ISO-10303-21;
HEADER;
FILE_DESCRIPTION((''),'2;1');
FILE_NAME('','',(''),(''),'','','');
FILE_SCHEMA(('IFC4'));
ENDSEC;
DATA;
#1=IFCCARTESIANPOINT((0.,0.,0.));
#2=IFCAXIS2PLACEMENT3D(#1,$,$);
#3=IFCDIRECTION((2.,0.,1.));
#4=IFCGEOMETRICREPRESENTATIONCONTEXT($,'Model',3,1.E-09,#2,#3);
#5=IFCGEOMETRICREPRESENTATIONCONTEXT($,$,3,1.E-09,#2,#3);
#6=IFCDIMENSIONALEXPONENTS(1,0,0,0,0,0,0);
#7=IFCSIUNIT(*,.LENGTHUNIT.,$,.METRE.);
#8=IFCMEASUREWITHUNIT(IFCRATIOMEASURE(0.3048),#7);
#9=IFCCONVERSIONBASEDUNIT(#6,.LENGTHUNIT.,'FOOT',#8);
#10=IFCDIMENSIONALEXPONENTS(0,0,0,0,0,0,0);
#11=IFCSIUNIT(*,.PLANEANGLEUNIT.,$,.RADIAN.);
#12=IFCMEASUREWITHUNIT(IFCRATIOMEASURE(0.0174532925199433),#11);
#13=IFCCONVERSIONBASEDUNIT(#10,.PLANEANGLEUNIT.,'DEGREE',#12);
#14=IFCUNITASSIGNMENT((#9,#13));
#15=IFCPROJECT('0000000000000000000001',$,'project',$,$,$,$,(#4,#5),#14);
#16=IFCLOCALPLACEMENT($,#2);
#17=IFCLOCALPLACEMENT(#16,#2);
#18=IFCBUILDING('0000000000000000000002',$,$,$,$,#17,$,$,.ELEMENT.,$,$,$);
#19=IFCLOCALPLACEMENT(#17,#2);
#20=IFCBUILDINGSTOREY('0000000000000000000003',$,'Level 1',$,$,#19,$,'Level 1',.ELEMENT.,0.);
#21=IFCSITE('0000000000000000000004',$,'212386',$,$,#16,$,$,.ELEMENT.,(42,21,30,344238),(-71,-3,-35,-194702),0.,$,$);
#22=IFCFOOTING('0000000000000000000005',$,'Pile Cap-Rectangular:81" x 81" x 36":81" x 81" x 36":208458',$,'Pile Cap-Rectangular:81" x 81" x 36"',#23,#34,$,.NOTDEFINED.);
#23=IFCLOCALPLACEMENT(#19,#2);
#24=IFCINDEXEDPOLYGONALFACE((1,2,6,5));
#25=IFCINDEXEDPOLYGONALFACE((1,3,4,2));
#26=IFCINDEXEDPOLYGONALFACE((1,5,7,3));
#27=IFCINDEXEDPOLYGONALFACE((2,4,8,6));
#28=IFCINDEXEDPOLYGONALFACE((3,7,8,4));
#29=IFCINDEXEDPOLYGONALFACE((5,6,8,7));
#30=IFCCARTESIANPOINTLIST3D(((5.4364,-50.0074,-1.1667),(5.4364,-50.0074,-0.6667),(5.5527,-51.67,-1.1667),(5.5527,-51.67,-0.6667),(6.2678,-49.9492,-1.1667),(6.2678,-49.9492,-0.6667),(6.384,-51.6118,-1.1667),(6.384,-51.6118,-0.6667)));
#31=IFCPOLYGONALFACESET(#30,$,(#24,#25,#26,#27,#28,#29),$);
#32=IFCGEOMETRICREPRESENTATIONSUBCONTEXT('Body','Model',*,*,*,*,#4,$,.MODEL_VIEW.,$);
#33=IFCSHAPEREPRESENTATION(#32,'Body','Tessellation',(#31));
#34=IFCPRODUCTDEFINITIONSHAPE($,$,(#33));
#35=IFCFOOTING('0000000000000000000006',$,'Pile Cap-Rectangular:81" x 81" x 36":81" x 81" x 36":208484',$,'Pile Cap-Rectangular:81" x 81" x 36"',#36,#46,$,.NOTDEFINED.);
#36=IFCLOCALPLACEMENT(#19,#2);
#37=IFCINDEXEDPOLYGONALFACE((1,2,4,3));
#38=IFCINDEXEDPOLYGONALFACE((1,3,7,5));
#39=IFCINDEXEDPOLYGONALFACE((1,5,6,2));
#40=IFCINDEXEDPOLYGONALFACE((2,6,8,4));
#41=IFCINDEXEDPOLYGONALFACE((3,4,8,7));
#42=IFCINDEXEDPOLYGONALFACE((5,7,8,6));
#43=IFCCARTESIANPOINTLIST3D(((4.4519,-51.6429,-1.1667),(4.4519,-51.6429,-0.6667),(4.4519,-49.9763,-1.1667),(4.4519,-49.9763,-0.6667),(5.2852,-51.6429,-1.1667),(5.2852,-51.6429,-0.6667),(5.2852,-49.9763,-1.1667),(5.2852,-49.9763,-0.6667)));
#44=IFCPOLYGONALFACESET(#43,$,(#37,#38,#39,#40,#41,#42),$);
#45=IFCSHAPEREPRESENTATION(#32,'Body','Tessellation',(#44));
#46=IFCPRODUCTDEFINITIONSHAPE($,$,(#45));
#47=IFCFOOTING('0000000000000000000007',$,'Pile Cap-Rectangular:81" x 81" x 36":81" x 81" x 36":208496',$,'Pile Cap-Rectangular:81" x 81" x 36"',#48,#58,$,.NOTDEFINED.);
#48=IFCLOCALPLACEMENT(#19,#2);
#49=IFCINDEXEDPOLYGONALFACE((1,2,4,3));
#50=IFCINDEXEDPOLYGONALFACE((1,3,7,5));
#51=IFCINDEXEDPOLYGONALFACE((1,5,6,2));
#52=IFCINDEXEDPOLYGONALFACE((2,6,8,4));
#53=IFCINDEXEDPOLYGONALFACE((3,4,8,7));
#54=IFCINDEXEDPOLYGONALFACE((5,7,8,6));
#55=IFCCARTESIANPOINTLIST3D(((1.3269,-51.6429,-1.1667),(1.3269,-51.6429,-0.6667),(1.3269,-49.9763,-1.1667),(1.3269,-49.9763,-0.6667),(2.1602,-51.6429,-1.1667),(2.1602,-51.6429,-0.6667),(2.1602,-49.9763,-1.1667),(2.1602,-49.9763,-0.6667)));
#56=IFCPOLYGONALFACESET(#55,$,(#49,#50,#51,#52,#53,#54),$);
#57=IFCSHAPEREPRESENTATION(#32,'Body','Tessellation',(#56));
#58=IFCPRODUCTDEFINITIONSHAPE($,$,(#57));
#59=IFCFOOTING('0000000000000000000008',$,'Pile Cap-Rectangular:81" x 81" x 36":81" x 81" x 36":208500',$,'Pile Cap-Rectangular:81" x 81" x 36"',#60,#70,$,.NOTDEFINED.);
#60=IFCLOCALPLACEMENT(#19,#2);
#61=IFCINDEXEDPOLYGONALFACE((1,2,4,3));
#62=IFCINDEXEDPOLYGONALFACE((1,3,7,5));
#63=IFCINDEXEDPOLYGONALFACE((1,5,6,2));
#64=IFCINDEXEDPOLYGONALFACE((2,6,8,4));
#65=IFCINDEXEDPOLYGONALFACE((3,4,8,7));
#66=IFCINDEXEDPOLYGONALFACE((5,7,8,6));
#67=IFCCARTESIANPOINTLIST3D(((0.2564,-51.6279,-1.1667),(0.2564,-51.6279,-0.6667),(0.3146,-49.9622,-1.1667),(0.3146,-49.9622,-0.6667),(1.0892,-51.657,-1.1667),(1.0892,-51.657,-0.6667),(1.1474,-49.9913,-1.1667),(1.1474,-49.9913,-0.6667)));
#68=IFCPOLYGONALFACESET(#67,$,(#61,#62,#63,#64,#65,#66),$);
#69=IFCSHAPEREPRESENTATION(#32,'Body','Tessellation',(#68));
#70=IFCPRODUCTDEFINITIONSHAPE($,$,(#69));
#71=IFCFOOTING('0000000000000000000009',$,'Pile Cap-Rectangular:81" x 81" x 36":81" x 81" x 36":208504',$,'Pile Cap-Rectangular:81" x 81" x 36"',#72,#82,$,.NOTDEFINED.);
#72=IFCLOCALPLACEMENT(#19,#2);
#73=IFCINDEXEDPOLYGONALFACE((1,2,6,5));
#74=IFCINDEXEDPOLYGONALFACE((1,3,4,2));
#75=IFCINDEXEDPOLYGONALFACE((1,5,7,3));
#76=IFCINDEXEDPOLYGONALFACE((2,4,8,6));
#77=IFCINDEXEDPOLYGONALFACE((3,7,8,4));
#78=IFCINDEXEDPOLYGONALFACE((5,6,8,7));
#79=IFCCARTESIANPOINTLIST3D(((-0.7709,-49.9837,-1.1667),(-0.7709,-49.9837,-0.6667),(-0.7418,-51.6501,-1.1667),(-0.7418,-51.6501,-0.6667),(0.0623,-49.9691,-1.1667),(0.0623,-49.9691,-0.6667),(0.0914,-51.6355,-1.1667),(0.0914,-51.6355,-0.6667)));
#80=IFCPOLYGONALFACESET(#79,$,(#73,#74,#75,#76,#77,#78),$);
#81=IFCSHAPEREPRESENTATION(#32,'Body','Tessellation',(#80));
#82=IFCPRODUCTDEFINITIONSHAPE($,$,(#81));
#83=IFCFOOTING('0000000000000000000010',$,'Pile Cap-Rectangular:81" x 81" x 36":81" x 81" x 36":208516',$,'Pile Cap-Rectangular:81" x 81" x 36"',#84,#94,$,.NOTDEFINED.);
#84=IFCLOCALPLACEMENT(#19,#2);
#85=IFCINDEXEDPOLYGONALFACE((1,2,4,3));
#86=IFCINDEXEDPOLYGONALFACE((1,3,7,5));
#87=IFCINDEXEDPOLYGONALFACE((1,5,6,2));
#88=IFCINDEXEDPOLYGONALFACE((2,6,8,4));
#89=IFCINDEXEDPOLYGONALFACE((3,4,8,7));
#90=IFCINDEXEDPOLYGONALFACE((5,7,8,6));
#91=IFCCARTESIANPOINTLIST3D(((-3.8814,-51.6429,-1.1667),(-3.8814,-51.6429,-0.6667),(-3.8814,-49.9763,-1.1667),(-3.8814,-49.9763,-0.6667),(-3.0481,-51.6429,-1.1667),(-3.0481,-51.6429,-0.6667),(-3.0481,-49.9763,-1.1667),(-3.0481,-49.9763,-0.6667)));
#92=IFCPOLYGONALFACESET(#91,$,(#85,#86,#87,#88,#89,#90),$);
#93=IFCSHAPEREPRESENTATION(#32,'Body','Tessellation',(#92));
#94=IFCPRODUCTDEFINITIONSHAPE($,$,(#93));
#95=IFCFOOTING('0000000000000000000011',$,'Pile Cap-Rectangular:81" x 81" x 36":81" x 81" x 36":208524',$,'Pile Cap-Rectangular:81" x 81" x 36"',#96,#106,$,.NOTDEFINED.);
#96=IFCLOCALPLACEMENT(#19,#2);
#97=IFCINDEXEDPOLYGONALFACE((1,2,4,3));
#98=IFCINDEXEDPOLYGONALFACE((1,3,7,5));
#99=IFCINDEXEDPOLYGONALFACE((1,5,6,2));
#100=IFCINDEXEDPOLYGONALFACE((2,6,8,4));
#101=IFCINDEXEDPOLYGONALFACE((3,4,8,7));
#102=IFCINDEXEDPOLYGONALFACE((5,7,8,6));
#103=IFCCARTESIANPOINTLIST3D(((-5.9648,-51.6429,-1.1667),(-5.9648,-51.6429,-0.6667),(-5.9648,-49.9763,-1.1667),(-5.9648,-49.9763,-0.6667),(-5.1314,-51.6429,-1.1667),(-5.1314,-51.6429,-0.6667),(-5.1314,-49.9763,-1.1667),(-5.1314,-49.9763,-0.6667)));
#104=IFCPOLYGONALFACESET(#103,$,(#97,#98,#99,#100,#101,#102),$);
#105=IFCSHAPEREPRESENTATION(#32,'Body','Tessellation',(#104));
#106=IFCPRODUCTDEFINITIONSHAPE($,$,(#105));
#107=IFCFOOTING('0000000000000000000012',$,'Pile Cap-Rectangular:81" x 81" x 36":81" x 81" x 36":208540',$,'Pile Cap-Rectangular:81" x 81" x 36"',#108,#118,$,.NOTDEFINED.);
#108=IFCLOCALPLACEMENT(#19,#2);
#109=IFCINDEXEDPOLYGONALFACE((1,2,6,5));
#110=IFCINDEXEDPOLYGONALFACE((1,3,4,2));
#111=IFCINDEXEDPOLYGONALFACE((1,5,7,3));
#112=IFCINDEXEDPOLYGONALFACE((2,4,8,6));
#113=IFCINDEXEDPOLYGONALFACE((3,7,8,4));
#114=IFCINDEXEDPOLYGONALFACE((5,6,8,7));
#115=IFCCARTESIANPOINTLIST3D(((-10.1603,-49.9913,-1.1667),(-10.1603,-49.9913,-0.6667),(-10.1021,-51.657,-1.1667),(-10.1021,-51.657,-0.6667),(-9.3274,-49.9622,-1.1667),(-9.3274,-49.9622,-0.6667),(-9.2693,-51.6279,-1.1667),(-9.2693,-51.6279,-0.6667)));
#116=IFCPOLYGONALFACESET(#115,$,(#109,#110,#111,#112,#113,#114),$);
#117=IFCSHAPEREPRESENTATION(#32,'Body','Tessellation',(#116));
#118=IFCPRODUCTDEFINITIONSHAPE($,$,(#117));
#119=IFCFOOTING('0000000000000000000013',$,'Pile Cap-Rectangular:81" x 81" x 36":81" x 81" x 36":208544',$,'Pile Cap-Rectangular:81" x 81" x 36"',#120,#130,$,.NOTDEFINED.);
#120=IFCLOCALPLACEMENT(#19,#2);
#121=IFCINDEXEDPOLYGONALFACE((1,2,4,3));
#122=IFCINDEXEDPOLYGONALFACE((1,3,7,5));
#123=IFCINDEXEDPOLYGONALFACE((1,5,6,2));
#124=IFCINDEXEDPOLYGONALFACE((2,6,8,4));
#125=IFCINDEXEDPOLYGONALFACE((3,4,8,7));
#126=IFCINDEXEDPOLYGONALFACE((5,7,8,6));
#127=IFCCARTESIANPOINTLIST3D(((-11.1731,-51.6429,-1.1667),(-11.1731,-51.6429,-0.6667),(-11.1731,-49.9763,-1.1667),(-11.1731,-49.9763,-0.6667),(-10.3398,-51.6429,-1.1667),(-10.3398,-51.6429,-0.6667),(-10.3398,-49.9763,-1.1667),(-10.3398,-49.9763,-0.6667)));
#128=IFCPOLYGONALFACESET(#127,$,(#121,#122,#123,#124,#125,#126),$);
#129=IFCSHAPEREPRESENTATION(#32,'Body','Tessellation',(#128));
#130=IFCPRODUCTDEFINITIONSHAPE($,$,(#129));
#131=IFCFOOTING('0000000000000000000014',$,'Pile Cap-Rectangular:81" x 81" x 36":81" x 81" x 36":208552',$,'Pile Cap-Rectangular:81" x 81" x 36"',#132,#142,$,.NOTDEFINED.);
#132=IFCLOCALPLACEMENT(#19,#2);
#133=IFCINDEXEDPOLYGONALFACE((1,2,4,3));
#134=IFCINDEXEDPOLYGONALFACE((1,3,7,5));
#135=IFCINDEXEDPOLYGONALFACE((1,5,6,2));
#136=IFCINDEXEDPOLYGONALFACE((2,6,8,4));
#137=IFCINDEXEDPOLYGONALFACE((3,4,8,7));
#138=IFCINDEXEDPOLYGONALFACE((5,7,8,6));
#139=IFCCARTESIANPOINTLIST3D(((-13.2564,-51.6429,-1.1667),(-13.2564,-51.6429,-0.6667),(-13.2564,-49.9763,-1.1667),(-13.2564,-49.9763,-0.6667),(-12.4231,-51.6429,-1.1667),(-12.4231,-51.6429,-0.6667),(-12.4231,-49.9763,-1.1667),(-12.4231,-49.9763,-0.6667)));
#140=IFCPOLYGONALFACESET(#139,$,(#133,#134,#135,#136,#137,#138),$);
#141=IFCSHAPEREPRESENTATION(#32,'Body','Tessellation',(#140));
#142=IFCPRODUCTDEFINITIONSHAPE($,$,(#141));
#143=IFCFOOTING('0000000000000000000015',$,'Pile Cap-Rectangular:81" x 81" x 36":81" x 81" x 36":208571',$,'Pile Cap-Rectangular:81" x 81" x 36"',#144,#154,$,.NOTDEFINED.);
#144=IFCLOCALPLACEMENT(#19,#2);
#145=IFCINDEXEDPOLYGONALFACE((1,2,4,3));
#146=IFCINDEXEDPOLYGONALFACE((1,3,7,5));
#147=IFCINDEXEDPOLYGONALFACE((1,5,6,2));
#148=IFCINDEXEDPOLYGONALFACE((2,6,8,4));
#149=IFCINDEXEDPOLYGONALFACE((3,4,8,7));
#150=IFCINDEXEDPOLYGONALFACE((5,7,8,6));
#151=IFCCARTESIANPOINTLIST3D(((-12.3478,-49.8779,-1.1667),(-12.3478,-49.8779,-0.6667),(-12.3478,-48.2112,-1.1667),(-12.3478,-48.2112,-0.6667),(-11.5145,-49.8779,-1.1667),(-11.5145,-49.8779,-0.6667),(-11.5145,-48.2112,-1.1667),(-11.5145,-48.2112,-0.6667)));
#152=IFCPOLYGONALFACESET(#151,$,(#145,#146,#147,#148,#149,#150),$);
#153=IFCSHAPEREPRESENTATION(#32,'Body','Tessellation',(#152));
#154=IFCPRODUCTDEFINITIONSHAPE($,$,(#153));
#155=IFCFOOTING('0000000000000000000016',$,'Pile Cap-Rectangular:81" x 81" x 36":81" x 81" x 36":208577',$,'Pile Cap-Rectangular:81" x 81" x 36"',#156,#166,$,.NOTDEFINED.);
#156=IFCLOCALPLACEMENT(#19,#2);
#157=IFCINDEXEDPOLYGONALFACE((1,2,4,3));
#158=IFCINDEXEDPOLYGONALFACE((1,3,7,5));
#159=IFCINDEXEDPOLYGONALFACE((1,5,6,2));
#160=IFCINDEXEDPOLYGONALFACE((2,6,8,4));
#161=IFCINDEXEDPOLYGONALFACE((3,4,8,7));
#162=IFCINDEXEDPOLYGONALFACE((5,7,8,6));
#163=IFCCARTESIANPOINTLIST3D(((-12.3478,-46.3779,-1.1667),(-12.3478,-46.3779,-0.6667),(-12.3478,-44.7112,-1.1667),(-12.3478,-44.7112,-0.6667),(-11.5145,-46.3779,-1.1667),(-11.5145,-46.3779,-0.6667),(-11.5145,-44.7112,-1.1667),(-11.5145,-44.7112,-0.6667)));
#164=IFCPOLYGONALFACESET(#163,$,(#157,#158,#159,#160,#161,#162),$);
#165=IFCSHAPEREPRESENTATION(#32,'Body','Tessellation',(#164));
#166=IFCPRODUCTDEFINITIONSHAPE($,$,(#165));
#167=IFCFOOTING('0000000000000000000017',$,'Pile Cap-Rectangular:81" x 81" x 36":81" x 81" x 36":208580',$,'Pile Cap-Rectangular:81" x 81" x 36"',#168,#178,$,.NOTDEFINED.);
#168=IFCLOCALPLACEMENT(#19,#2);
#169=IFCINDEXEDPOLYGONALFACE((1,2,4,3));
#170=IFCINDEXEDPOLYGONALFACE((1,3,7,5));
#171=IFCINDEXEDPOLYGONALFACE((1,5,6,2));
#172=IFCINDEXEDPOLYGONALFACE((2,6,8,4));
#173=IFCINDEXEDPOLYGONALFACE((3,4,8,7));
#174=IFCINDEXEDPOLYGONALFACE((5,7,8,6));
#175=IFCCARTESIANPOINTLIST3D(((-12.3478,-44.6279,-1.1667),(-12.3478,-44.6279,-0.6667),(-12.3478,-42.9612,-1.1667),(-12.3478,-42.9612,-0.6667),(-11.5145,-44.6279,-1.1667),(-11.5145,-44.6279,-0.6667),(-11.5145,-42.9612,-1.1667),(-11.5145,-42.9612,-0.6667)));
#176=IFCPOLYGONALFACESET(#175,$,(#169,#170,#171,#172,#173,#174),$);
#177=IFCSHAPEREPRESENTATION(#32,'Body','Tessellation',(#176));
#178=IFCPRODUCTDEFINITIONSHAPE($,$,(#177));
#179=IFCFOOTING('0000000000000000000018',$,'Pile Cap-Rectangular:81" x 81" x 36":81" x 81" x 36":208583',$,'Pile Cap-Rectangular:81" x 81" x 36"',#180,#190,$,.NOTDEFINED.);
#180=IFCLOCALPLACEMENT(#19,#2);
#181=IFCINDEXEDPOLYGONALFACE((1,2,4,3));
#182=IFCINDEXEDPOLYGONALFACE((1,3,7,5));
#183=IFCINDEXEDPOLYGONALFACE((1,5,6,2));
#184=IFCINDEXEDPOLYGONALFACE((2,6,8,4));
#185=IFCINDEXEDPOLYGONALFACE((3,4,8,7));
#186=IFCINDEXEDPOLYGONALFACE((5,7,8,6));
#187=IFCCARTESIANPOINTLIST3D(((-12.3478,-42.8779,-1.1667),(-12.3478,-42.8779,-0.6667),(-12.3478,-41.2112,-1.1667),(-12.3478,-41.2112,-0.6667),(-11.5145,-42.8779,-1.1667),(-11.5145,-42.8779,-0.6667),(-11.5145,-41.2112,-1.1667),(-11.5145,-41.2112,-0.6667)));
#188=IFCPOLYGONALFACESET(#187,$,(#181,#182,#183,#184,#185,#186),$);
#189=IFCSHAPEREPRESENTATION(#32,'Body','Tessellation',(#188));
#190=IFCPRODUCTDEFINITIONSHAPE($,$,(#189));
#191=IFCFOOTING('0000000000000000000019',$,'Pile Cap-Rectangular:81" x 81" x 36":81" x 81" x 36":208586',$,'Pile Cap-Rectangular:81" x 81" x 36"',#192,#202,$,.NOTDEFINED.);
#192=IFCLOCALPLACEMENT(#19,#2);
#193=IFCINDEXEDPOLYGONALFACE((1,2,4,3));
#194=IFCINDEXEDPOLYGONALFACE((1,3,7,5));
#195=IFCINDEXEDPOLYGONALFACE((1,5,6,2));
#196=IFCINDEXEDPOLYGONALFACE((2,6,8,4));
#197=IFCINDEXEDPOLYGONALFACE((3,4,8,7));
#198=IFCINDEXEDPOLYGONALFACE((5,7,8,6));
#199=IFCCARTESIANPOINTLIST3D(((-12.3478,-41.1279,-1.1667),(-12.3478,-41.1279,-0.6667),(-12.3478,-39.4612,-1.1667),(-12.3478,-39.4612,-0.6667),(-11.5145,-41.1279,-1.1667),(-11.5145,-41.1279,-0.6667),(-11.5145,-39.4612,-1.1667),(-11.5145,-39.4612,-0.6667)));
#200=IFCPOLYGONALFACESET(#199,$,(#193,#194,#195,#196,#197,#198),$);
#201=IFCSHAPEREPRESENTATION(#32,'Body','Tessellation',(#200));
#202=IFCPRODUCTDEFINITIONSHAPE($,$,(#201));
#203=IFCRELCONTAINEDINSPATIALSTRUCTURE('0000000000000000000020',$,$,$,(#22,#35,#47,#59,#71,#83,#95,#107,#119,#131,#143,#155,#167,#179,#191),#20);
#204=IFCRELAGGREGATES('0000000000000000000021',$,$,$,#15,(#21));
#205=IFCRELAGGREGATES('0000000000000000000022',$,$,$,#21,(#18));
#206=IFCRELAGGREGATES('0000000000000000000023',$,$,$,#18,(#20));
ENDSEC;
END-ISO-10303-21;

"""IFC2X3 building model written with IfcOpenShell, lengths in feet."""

from ifc_helpers import new_model, entity, si_unit, converted_unit, direction, frame, frame_2d, origin, origin_2d_with_axis, place, context, subcontext, project, spatial, rectangle, extrude, element, save


model = new_model("IFC2X3")

# Units and contexts
model_context = context("Model", 3, precision=1e-09, world=origin(), true_north=direction((2.0, 0.0, 1.0)))
context_of_model = context(None, 3, precision=1e-09, world=origin(), true_north=direction((2.0, 0.0, 1.0)))
body_context = subcontext(model_context, "Body", "Model", "MODEL_VIEW")
ifc_project = project(units=[converted_unit("LENGTHUNIT", "FOOT", entity("IfcRatioMeasure", 0.3048), si_unit("LENGTHUNIT", "METRE"), dimensions=[1, 0, 0, 0, 0, 0, 0]), converted_unit("PLANEANGLEUNIT", "DEGREE", entity("IfcRatioMeasure", 0.0174532925199433), si_unit("PLANEANGLEUNIT", "RADIAN"), dimensions=[0, 0, 0, 0, 0, 0, 0])], contexts=[model_context, context_of_model])

# Site, building, storey
site_placement = place(None, origin())
site = spatial("IfcSite", under=ifc_project, at=site_placement, Name="212386", CompositionType="ELEMENT", RefLatitude=(42, 21, 30, 344238), RefLongitude=(-71, -3, -35, -194702), RefElevation=0.0)
building_placement = place(site_placement, origin())
building = spatial("IfcBuilding", under=site, at=building_placement, CompositionType="ELEMENT")
storey_placement = place(building_placement, origin())
storey = spatial("IfcBuildingStorey", under=building, at=storey_placement, Name="Level 1", LongName="Level 1", CompositionType="ELEMENT", Elevation=0.0)

# Footings
footing_1_placement = place(storey_placement, origin())
element("IfcFooting", 1, at=footing_1_placement, inside=storey, Name="Pile Cap-Rectangular:81\" x 81\" x 36\":81\" x 81\" x 36\":208458", ObjectType="Pile Cap-Rectangular:81\" x 81\" x 36\"", PredefinedType="NOTDEFINED", context=body_context, shape_type="SweptSolid", body=[
    extrude(rectangle(XDim=0.8333, YDim=1.6667, at=frame_2d((0.0, 0.0), x_axis=(1.0, 0.0))), frame((5.9102, -50.8096, -1.1667), z_axis=(0.0, 0.0, 1.0), x_axis=(-0.997564, -0.069756, 0.0)), (0.0, 0.0, 1.0), 0.5),
])
footing_2_placement = place(storey_placement, origin())
element("IfcFooting", 2, at=footing_2_placement, inside=storey, Name="Pile Cap-Rectangular:81\" x 81\" x 36\":81\" x 81\" x 36\":208484", ObjectType="Pile Cap-Rectangular:81\" x 81\" x 36\"", PredefinedType="NOTDEFINED", context=body_context, shape_type="SweptSolid", body=[
    extrude(rectangle(XDim=0.8333, YDim=1.6667, at=frame_2d((0.0, 0.0), x_axis=(1.0, 0.0))), frame((4.8686, -50.8096, -1.1667), z_axis=(0.0, 0.0, 1.0), x_axis=(-1.0, 0.0, 0.0)), (0.0, 0.0, 1.0), 0.5),
])
footing_3_placement = place(storey_placement, origin())
element("IfcFooting", 3, at=footing_3_placement, inside=storey, Name="Pile Cap-Rectangular:81\" x 81\" x 36\":81\" x 81\" x 36\":208496", ObjectType="Pile Cap-Rectangular:81\" x 81\" x 36\"", PredefinedType="NOTDEFINED", context=body_context, shape_type="SweptSolid", body=[
    extrude(rectangle(XDim=0.8333, YDim=1.6667, at=frame_2d((0.0, 0.0), x_axis=(1.0, 0.0))), frame((1.7436, -50.8096, -1.1667), z_axis=(0.0, 0.0, 1.0), x_axis=(-1.0, 0.0, 0.0)), (0.0, 0.0, 1.0), 0.5),
])
footing_4_placement = place(storey_placement, origin())
element("IfcFooting", 4, at=footing_4_placement, inside=storey, Name="Pile Cap-Rectangular:81\" x 81\" x 36\":81\" x 81\" x 36\":208500", ObjectType="Pile Cap-Rectangular:81\" x 81\" x 36\"", PredefinedType="NOTDEFINED", context=body_context, shape_type="SweptSolid", body=[
    extrude(rectangle(XDim=0.8333, YDim=1.6667, at=frame_2d((0.0, 0.0), x_axis=(1.0, 0.0))), frame((0.7019, -50.8096, -1.1667), z_axis=(0.0, 0.0, 1.0), x_axis=(-0.999391, 0.034899, 0.0)), (0.0, 0.0, 1.0), 0.5),
])
footing_5_placement = place(storey_placement, origin())
element("IfcFooting", 5, at=footing_5_placement, inside=storey, Name="Pile Cap-Rectangular:81\" x 81\" x 36\":81\" x 81\" x 36\":208504", ObjectType="Pile Cap-Rectangular:81\" x 81\" x 36\"", PredefinedType="NOTDEFINED", context=body_context, shape_type="SweptSolid", body=[
    extrude(rectangle(XDim=0.8333, YDim=1.6667, at=frame_2d((0.0, 0.0), x_axis=(1.0, 0.0))), frame((-0.3398, -50.8096, -1.1667), z_axis=(0.0, 0.0, 1.0), x_axis=(-0.999848, -0.017452, 0.0)), (0.0, 0.0, 1.0), 0.5),
])
footing_6_placement = place(storey_placement, origin())
element("IfcFooting", 6, at=footing_6_placement, inside=storey, Name="Pile Cap-Rectangular:81\" x 81\" x 36\":81\" x 81\" x 36\":208516", ObjectType="Pile Cap-Rectangular:81\" x 81\" x 36\"", PredefinedType="NOTDEFINED", context=body_context, shape_type="SweptSolid", body=[
    extrude(rectangle(XDim=0.8333, YDim=1.6667, at=frame_2d((0.0, 0.0), x_axis=(1.0, 0.0))), frame((-3.4648, -50.8096, -1.1667), z_axis=(0.0, 0.0, 1.0), x_axis=(-1.0, 0.0, 0.0)), (0.0, 0.0, 1.0), 0.5),
])
footing_7_placement = place(storey_placement, origin())
element("IfcFooting", 7, at=footing_7_placement, inside=storey, Name="Pile Cap-Rectangular:81\" x 81\" x 36\":81\" x 81\" x 36\":208524", ObjectType="Pile Cap-Rectangular:81\" x 81\" x 36\"", PredefinedType="NOTDEFINED", context=body_context, shape_type="SweptSolid", body=[
    extrude(rectangle(XDim=0.8333, YDim=1.6667, at=frame_2d((0.0, 0.0), x_axis=(1.0, 0.0))), frame((-5.5481, -50.8096, -1.1667), z_axis=(0.0, 0.0, 1.0), x_axis=(-1.0, 0.0, 0.0)), (0.0, 0.0, 1.0), 0.5),
])
footing_8_placement = place(storey_placement, origin())
element("IfcFooting", 8, at=footing_8_placement, inside=storey, Name="Pile Cap-Rectangular:81\" x 81\" x 36\":81\" x 81\" x 36\":208540", ObjectType="Pile Cap-Rectangular:81\" x 81\" x 36\"", PredefinedType="NOTDEFINED", context=body_context, shape_type="SweptSolid", body=[
    extrude(rectangle(XDim=0.8333, YDim=1.6667, at=origin_2d_with_axis()), frame((-9.7148, -50.8096, -1.1667), z_axis=(0.0, 0.0, 1.0), x_axis=(-0.999391, -0.034899, 0.0)), (0.0, 0.0, 1.0), 0.5),
])
footing_9_placement = place(storey_placement, origin())
element("IfcFooting", 9, at=footing_9_placement, inside=storey, Name="Pile Cap-Rectangular:81\" x 81\" x 36\":81\" x 81\" x 36\":208544", ObjectType="Pile Cap-Rectangular:81\" x 81\" x 36\"", PredefinedType="NOTDEFINED", context=body_context, shape_type="SweptSolid", body=[
    extrude(rectangle(XDim=0.8333, YDim=1.6667, at=frame_2d((0.0, 0.0), x_axis=(1.0, 0.0))), frame((-10.7564, -50.8096, -1.1667), z_axis=(0.0, 0.0, 1.0), x_axis=(-1.0, 0.0, 0.0)), (0.0, 0.0, 1.0), 0.5),
])
footing_10_placement = place(storey_placement, origin())
element("IfcFooting", 10, at=footing_10_placement, inside=storey, Name="Pile Cap-Rectangular:81\" x 81\" x 36\":81\" x 81\" x 36\":208552", ObjectType="Pile Cap-Rectangular:81\" x 81\" x 36\"", PredefinedType="NOTDEFINED", context=body_context, shape_type="SweptSolid", body=[
    extrude(rectangle(XDim=0.8333, YDim=1.6667, at=frame_2d((0.0, 0.0), x_axis=(1.0, 0.0))), frame((-12.8398, -50.8096, -1.1667), z_axis=(0.0, 0.0, 1.0), x_axis=(-1.0, 0.0, 0.0)), (0.0, 0.0, 1.0), 0.5),
])
footing_11_placement = place(storey_placement, origin())
element("IfcFooting", 11, at=footing_11_placement, inside=storey, Name="Pile Cap-Rectangular:81\" x 81\" x 36\":81\" x 81\" x 36\":208571", ObjectType="Pile Cap-Rectangular:81\" x 81\" x 36\"", PredefinedType="NOTDEFINED", context=body_context, shape_type="SweptSolid", body=[
    extrude(rectangle(XDim=0.8333, YDim=1.6667, at=frame_2d((0.0, 0.0), x_axis=(1.0, 0.0))), frame((-11.9311, -49.0446, -1.1667), z_axis=(0.0, 0.0, 1.0), x_axis=(-1.0, 0.0, 0.0)), (0.0, 0.0, 1.0), 0.5),
])
footing_12_placement = place(storey_placement, origin())
element("IfcFooting", 12, at=footing_12_placement, inside=storey, Name="Pile Cap-Rectangular:81\" x 81\" x 36\":81\" x 81\" x 36\":208577", ObjectType="Pile Cap-Rectangular:81\" x 81\" x 36\"", PredefinedType="NOTDEFINED", context=body_context, shape_type="SweptSolid", body=[
    extrude(rectangle(XDim=0.8333, YDim=1.6667, at=frame_2d((0.0, 0.0), x_axis=(1.0, 0.0))), frame((-11.9311, -45.5446, -1.1667), z_axis=(0.0, 0.0, 1.0), x_axis=(-1.0, 0.0, 0.0)), (0.0, 0.0, 1.0), 0.5),
])
footing_13_placement = place(storey_placement, origin())
element("IfcFooting", 13, at=footing_13_placement, inside=storey, Name="Pile Cap-Rectangular:81\" x 81\" x 36\":81\" x 81\" x 36\":208580", ObjectType="Pile Cap-Rectangular:81\" x 81\" x 36\"", PredefinedType="NOTDEFINED", context=body_context, shape_type="SweptSolid", body=[
    extrude(rectangle(XDim=0.8333, YDim=1.6667, at=frame_2d((0.0, 0.0), x_axis=(1.0, 0.0))), frame((-11.9311, -43.7946, -1.1667), z_axis=(0.0, 0.0, 1.0), x_axis=(-1.0, 0.0, 0.0)), (0.0, 0.0, 1.0), 0.5),
])
footing_14_placement = place(storey_placement, origin())
element("IfcFooting", 14, at=footing_14_placement, inside=storey, Name="Pile Cap-Rectangular:81\" x 81\" x 36\":81\" x 81\" x 36\":208583", ObjectType="Pile Cap-Rectangular:81\" x 81\" x 36\"", PredefinedType="NOTDEFINED", context=body_context, shape_type="SweptSolid", body=[
    extrude(rectangle(XDim=0.8333, YDim=1.6667, at=frame_2d((0.0, 0.0), x_axis=(1.0, 0.0))), frame((-11.9311, -42.0446, -1.1667), z_axis=(0.0, 0.0, 1.0), x_axis=(-1.0, 0.0, 0.0)), (0.0, 0.0, 1.0), 0.5),
])
footing_15_placement = place(storey_placement, origin())
element("IfcFooting", 15, at=footing_15_placement, inside=storey, Name="Pile Cap-Rectangular:81\" x 81\" x 36\":81\" x 81\" x 36\":208586", ObjectType="Pile Cap-Rectangular:81\" x 81\" x 36\"", PredefinedType="NOTDEFINED", context=body_context, shape_type="SweptSolid", body=[
    extrude(rectangle(XDim=0.8333, YDim=1.6667, at=frame_2d((0.0, 0.0), x_axis=(1.0, 0.0))), frame((-11.9311, -40.2946, -1.1667), z_axis=(0.0, 0.0, 1.0), x_axis=(-1.0, 0.0, 0.0)), (0.0, 0.0, 1.0), 0.5),
])

save(model, "model.ifc")
